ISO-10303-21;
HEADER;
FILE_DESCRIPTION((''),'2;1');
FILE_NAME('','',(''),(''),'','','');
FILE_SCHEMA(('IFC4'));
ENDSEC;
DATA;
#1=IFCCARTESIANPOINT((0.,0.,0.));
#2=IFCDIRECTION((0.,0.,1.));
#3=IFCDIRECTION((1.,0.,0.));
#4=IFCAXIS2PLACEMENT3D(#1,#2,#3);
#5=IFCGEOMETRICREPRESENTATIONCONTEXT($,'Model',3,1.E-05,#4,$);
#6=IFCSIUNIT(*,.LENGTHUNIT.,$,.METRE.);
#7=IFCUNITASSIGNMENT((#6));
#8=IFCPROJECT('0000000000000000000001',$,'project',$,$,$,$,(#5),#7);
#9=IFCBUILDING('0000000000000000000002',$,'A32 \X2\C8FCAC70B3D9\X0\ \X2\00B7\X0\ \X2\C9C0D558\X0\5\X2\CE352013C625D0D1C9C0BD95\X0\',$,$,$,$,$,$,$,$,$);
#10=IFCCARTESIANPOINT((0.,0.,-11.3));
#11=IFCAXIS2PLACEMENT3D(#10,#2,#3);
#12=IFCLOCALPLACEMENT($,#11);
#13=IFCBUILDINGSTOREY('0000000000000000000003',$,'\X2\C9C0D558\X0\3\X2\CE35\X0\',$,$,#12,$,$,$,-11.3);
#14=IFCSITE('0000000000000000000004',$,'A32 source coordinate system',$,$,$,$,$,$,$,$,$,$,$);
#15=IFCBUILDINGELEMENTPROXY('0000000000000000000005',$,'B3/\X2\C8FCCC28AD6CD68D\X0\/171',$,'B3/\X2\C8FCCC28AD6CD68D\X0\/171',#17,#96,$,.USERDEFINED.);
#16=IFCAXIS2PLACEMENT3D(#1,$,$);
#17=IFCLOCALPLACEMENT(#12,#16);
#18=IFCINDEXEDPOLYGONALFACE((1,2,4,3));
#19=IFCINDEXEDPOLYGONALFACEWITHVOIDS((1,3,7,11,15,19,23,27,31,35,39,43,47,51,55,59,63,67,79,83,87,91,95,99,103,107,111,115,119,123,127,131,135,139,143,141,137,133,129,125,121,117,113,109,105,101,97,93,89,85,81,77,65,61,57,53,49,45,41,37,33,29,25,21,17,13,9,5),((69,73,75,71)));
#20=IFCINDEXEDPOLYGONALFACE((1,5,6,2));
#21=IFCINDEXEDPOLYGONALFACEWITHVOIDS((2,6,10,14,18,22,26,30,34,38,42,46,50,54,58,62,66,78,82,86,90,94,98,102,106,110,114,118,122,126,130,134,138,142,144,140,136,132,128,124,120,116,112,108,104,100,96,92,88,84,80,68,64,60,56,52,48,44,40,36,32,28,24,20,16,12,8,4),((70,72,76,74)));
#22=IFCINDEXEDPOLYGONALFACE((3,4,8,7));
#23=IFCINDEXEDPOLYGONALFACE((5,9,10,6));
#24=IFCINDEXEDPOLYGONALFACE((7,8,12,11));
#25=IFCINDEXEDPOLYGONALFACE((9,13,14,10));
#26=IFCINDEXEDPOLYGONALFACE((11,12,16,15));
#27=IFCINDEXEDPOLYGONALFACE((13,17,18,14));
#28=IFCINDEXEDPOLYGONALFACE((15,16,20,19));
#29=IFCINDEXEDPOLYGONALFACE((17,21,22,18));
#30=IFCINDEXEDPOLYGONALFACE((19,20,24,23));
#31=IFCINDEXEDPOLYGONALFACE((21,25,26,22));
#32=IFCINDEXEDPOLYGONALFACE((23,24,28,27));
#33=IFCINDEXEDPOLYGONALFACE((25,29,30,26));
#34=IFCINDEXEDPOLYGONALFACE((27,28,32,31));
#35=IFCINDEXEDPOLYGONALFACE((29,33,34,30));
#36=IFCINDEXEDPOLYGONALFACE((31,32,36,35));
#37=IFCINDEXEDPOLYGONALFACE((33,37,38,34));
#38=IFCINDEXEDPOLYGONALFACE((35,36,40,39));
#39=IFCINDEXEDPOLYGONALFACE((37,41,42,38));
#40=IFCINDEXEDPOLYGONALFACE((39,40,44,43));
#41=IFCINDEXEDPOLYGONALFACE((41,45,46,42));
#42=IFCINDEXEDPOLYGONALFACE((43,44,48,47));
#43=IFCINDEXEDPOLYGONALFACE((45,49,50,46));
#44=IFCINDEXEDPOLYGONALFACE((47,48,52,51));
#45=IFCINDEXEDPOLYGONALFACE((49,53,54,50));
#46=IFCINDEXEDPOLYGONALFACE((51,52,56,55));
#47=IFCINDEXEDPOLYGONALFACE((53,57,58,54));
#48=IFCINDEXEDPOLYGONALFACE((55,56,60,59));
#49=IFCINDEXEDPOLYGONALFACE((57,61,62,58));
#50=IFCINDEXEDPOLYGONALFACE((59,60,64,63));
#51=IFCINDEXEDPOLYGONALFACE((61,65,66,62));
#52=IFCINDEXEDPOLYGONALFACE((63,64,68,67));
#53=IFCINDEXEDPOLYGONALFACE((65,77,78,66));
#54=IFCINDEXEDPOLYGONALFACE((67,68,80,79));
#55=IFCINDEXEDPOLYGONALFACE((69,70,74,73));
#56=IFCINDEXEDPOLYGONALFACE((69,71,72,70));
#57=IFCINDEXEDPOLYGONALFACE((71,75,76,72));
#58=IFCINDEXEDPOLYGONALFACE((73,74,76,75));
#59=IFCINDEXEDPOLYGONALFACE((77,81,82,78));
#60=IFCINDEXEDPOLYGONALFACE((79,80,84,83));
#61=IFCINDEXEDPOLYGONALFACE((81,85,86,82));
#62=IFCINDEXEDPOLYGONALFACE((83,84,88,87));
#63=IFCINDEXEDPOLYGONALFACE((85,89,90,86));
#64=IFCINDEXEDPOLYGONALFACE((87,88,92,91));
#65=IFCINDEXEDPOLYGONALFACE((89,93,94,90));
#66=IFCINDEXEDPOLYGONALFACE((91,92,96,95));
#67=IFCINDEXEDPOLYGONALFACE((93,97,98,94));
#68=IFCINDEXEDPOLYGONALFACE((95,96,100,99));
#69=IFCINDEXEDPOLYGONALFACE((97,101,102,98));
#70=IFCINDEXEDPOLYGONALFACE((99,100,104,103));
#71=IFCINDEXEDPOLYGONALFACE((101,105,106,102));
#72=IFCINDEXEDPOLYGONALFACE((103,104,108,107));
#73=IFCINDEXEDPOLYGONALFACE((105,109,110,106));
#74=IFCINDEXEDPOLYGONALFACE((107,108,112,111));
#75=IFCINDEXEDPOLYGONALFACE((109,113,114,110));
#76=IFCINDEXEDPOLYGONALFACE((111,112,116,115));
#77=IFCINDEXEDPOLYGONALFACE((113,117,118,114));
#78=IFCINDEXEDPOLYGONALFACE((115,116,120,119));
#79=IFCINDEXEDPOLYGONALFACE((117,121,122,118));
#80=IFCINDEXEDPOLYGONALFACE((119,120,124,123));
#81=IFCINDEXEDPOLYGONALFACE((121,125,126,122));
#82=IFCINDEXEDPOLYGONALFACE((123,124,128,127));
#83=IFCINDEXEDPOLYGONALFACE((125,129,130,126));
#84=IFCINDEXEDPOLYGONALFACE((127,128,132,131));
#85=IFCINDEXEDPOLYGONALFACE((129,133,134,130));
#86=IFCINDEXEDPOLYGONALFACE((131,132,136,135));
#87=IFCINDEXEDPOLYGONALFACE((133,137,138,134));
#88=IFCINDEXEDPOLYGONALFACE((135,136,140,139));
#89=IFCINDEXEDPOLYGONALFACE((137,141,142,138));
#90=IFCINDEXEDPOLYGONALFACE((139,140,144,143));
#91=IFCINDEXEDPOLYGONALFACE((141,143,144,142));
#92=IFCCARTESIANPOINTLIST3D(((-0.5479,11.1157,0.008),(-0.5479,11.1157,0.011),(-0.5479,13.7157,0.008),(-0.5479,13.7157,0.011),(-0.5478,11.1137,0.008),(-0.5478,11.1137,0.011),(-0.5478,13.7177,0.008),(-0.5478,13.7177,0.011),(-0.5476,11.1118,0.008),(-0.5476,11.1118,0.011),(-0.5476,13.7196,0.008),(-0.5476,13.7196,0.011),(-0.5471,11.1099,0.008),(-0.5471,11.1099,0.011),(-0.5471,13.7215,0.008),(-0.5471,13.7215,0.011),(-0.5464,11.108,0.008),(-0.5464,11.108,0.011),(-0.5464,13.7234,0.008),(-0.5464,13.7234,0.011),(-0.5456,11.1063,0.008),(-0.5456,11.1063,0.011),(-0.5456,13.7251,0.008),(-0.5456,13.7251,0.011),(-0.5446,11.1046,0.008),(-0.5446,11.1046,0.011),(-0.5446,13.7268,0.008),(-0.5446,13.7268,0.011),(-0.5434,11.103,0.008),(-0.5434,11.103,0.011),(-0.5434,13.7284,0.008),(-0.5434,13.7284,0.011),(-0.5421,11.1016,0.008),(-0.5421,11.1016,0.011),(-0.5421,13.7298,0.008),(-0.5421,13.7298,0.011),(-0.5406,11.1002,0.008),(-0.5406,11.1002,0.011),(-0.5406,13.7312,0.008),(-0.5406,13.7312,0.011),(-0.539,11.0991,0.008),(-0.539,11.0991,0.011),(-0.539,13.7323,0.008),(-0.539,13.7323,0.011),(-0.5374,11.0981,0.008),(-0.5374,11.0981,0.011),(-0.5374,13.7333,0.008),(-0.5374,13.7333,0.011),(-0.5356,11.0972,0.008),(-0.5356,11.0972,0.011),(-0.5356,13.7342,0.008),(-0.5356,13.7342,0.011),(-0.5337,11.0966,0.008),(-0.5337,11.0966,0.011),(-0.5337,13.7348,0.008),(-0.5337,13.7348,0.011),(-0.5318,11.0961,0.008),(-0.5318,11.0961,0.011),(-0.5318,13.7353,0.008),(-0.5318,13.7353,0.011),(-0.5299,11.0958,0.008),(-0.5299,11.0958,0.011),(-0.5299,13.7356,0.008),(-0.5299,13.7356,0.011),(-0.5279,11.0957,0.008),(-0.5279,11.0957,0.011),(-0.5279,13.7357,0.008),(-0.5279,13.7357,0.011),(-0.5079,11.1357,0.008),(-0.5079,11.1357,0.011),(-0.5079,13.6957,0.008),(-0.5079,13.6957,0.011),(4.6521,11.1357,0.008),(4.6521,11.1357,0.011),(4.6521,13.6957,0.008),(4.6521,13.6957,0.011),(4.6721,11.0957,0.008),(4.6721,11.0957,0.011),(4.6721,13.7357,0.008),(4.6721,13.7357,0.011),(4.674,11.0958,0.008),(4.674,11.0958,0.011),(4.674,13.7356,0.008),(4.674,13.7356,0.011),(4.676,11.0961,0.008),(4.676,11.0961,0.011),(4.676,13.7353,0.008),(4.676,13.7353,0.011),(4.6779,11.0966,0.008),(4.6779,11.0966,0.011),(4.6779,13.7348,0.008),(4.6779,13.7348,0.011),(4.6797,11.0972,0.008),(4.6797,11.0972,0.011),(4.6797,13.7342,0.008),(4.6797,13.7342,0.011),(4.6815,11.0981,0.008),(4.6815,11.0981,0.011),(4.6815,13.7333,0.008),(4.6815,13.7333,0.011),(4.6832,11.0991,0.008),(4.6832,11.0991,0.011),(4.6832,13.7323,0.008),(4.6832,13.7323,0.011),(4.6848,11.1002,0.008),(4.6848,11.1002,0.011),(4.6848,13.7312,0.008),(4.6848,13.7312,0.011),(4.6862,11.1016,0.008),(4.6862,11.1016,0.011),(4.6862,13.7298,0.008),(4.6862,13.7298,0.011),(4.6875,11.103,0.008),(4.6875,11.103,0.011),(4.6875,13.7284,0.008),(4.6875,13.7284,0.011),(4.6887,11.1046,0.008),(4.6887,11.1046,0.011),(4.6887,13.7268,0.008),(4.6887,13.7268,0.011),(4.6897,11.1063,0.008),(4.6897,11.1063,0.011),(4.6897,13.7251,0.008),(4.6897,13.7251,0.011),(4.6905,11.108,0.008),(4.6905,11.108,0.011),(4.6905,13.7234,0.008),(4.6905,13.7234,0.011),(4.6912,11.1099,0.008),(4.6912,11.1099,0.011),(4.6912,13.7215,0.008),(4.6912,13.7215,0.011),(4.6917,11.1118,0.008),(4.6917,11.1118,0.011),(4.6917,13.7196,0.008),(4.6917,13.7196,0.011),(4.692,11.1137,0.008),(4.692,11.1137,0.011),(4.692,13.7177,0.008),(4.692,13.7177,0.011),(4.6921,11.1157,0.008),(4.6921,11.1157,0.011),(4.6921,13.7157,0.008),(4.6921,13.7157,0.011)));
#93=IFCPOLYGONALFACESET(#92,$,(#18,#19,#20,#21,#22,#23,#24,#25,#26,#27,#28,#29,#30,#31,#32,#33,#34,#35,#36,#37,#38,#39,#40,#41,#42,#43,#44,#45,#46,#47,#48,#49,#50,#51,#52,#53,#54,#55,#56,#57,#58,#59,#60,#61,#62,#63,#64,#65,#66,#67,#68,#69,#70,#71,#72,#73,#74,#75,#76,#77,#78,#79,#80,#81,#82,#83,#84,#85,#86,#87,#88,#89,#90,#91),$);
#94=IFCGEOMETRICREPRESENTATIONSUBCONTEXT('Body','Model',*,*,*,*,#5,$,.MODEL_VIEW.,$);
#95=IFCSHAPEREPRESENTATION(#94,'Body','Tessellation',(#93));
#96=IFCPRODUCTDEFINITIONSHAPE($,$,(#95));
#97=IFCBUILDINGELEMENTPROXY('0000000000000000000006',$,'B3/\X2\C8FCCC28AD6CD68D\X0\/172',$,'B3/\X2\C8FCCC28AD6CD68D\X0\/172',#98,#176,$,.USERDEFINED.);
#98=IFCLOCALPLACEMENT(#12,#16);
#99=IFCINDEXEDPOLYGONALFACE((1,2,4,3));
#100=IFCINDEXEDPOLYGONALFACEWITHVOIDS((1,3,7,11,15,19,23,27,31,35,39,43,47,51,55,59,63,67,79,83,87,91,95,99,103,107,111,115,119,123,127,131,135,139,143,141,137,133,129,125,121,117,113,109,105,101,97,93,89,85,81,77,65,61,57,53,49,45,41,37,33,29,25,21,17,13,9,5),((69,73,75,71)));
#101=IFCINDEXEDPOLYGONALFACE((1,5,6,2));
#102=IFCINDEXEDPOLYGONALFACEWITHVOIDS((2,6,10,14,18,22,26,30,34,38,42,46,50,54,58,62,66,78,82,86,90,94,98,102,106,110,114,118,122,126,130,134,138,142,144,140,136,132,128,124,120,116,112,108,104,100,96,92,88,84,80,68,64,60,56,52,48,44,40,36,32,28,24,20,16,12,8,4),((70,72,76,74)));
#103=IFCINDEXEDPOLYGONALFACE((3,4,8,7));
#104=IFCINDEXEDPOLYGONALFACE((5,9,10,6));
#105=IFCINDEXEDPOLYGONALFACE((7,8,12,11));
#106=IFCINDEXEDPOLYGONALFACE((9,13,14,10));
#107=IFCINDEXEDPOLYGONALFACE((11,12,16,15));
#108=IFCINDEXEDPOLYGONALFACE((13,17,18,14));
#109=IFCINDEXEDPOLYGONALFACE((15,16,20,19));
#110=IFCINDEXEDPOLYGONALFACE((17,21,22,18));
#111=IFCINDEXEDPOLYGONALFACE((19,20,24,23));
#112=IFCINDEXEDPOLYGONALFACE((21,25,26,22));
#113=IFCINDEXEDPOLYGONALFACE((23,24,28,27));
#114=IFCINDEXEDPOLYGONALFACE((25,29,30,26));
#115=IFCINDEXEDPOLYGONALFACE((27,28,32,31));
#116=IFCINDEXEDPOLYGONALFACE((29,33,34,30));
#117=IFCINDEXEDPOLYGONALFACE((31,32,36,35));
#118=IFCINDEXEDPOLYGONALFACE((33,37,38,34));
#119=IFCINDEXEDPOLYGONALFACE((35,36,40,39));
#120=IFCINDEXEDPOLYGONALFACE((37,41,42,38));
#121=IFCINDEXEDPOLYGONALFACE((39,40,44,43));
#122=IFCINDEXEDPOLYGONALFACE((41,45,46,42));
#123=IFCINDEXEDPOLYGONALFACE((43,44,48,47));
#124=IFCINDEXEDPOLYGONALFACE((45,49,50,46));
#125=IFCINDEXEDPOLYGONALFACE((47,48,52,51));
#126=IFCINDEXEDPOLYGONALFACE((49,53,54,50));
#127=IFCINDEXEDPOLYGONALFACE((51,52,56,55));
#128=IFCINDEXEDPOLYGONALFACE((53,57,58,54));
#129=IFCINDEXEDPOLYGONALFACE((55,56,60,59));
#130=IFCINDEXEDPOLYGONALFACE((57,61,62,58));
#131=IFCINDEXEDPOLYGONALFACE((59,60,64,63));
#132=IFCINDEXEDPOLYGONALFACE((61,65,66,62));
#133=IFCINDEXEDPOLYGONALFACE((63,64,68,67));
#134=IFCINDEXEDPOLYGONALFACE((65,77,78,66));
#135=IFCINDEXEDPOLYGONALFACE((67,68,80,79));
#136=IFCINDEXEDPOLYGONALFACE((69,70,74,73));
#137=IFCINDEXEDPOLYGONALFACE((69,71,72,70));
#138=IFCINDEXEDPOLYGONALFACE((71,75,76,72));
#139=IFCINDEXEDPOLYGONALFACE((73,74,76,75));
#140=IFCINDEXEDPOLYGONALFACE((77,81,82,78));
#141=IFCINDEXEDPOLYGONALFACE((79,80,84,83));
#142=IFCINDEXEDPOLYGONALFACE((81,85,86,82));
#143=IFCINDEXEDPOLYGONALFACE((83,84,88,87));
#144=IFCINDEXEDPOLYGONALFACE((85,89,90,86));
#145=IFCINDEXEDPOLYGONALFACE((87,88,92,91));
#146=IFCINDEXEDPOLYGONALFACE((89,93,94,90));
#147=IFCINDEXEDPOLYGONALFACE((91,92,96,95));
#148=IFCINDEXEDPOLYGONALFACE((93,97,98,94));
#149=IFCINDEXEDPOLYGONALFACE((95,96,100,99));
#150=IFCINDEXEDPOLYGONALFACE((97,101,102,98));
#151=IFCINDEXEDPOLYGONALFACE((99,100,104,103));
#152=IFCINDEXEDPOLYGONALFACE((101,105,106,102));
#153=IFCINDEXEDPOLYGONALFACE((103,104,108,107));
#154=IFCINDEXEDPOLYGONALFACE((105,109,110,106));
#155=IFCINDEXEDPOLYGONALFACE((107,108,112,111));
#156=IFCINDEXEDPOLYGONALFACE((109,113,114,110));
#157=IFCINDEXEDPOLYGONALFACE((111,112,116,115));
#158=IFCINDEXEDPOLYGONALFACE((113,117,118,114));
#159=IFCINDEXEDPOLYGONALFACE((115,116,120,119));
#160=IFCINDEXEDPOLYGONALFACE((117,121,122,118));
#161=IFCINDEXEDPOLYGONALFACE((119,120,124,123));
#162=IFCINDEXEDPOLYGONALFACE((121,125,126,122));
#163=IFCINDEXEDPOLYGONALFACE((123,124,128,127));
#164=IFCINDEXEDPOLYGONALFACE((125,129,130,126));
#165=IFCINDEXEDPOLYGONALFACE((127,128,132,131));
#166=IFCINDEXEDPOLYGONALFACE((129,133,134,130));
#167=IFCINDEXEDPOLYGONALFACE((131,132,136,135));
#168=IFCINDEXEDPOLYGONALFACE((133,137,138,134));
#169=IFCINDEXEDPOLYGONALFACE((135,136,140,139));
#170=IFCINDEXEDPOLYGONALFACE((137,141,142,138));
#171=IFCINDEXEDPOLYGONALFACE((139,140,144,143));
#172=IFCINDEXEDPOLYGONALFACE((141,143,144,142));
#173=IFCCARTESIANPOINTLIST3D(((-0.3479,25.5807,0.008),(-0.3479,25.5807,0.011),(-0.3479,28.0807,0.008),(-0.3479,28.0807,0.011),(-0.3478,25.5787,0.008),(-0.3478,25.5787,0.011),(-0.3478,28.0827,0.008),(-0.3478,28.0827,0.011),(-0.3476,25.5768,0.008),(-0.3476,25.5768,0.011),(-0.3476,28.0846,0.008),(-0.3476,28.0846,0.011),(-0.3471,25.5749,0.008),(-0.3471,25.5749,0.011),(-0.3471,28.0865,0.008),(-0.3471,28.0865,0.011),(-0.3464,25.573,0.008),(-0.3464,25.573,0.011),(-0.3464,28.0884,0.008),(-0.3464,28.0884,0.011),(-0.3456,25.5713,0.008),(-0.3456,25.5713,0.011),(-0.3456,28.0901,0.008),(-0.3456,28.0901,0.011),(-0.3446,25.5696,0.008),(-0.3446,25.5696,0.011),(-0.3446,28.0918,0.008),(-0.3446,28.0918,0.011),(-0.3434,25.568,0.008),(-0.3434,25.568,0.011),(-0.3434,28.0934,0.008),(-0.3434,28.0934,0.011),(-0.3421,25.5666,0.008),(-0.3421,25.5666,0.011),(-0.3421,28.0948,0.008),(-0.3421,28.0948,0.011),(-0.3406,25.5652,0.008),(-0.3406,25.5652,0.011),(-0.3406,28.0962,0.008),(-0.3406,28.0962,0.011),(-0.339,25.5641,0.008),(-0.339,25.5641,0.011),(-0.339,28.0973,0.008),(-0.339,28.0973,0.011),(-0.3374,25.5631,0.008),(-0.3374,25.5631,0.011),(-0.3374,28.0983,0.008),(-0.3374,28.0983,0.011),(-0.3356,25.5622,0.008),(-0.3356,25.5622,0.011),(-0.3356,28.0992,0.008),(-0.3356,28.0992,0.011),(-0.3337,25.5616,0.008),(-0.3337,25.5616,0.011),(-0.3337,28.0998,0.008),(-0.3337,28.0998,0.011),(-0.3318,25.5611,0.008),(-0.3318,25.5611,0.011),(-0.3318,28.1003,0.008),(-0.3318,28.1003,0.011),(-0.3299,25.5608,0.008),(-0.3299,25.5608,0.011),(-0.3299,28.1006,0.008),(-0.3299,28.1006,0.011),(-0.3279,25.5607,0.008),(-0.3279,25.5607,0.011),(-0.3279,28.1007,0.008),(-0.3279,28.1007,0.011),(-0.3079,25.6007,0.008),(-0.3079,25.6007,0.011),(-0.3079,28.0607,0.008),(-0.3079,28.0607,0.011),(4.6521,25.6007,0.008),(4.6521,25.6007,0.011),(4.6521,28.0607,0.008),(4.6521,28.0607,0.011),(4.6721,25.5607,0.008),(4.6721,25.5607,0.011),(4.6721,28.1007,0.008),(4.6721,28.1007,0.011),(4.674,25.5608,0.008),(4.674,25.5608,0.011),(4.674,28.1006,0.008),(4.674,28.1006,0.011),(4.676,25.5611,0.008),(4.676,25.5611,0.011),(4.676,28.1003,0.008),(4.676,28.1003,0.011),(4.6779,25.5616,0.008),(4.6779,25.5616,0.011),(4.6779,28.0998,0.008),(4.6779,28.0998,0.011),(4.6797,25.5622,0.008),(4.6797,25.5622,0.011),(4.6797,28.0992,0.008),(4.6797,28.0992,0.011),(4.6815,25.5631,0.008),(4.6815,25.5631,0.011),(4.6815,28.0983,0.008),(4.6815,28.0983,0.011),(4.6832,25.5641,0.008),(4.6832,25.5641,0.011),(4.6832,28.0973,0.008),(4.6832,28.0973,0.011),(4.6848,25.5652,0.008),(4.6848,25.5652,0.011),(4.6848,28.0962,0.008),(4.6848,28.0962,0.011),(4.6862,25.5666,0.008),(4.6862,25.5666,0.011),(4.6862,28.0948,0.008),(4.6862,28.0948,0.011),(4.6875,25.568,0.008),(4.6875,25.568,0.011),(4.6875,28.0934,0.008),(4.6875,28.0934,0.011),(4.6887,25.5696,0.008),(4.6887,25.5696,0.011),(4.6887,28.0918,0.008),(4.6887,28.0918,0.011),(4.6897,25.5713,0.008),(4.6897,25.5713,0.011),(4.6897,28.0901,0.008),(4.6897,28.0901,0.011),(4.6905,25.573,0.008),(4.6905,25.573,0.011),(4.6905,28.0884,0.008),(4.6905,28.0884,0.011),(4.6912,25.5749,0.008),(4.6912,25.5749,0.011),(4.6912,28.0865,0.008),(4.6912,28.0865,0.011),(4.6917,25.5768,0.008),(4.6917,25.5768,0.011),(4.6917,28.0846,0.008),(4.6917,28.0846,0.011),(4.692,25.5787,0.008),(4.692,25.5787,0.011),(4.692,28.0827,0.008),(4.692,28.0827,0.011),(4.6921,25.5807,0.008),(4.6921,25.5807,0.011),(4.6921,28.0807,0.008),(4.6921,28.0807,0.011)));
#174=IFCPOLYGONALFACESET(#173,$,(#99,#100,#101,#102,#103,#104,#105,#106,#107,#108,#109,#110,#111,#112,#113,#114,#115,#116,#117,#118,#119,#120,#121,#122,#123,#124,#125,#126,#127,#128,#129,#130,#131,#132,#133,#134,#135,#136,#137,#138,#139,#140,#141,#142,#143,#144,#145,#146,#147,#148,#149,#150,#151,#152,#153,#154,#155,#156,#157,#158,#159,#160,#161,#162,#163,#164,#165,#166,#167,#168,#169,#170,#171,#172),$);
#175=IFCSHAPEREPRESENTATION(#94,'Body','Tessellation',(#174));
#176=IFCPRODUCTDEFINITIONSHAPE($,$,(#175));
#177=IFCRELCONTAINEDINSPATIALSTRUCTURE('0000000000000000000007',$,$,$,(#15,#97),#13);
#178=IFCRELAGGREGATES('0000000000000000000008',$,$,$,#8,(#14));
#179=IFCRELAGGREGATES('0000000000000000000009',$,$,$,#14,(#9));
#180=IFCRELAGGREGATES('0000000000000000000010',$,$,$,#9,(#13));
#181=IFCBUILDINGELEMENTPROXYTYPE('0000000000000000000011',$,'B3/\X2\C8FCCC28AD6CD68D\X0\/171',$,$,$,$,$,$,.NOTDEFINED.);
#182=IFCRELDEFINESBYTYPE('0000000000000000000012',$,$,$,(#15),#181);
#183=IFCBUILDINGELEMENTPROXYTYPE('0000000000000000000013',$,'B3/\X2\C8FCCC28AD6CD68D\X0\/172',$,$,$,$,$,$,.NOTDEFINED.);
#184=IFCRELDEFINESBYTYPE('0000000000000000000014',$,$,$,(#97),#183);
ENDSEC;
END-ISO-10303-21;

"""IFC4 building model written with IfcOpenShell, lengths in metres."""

from ifc_helpers import new_model, si_unit, frame, origin, origin_with_axes, place, context, subcontext, project, spatial, polyline, outline, extrude, source, transform, mapped, type_object, type_shapes, element, save


model = new_model("IFC4")

# Units and contexts
model_context = context("Model", 3, precision=1e-05, world=origin_with_axes())
body_context = subcontext(model_context, "Body", "Model", "MODEL_VIEW")
ifc_project = project(units=[si_unit("LENGTHUNIT", "METRE")], contexts=[model_context])

# Site, building, storey
site = spatial("IfcSite", under=ifc_project, Name="A32 source coordinate system")
building = spatial("IfcBuilding", under=site, Name="A32 주거동 · 지하5층–옥탑지붕")
storey_placement = place(None, frame((0.0, 0.0, -11.3), z_axis=(0.0, 0.0, 1.0), x_axis=(1.0, 0.0, 0.0)))
storey = spatial("IfcBuildingStorey", under=building, at=storey_placement, Name="지하3층", Elevation=-11.3)

# Building element proxies
building_element_proxy_type_1 = type_object("IfcBuildingElementProxyType", Name="B3/주차구획/171", PredefinedType="NOTDEFINED")
shared_shape_1 = source(origin(), body_context, "Body", "SweptSolid", [
    extrude(outline(polyline([(-0.5279, 11.0957), (-0.5299, 11.0958), (-0.5318, 11.0961), (-0.5337, 11.0966), (-0.5356, 11.0972), (-0.5374, 11.0981), (-0.539, 11.0991), (-0.5406, 11.1002), (-0.5421, 11.1016), (-0.5434, 11.103), (-0.5446, 11.1046), (-0.5456, 11.1063), (-0.5464, 11.108), (-0.5471, 11.1099), (-0.5476, 11.1118), (-0.5478, 11.1137), (-0.5479, 11.1157), (-0.5479, 13.7157), (-0.5478, 13.7177), (-0.5476, 13.7196), (-0.5471, 13.7215), (-0.5464, 13.7234), (-0.5456, 13.7251), (-0.5446, 13.7268), (-0.5434, 13.7284), (-0.5421, 13.7298), (-0.5406, 13.7312), (-0.539, 13.7323), (-0.5374, 13.7333), (-0.5356, 13.7342), (-0.5337, 13.7348), (-0.5318, 13.7353), (-0.5299, 13.7356), (-0.5279, 13.7357), (4.6721, 13.7357), (4.674, 13.7356), (4.676, 13.7353), (4.6779, 13.7348), (4.6797, 13.7342), (4.6815, 13.7333), (4.6832, 13.7323), (4.6848, 13.7312), (4.6862, 13.7298), (4.6875, 13.7284), (4.6887, 13.7268), (4.6897, 13.7251), (4.6905, 13.7234), (4.6912, 13.7215), (4.6917, 13.7196), (4.692, 13.7177), (4.6921, 13.7157), (4.6921, 11.1157), (4.692, 11.1137), (4.6917, 11.1118), (4.6912, 11.1099), (4.6905, 11.108), (4.6897, 11.1063), (4.6887, 11.1046), (4.6875, 11.103), (4.6862, 11.1016), (4.6848, 11.1002), (4.6832, 11.0991), (4.6815, 11.0981), (4.6797, 11.0972), (4.6779, 11.0966), (4.676, 11.0961), (4.674, 11.0958), (4.6721, 11.0957), (-0.5279, 11.0957)]), holes=[polyline([(-0.5079, 11.1357), (4.6521, 11.1357), (4.6521, 13.6957), (-0.5079, 13.6957), (-0.5079, 11.1357)])]), frame((0.0, 0.0, 0.008)), (0.0, 0.0, 1.0), 0.003),
])
type_shapes(building_element_proxy_type_1, [shared_shape_1])
proxy_1_placement = place(storey_placement, origin_with_axes())
element("IfcBuildingElementProxy", 1, at=proxy_1_placement, inside=storey, type_object=building_element_proxy_type_1, Name="B3/주차구획/171", ObjectType="B3/주차구획/171", PredefinedType="USERDEFINED", context=body_context, shape_type="MappedRepresentation", body=[
    mapped(shared_shape_1, transform((0.0, 0.0, 0.0), scale=1.0)),
])
building_element_proxy_type_2 = type_object("IfcBuildingElementProxyType", Name="B3/주차구획/172", PredefinedType="NOTDEFINED")
shared_shape_2 = source(origin(), body_context, "Body", "SweptSolid", [
    extrude(outline(polyline([(-0.3279, 25.5607), (-0.3299, 25.5608), (-0.3318, 25.5611), (-0.3337, 25.5616), (-0.3356, 25.5622), (-0.3374, 25.5631), (-0.339, 25.5641), (-0.3406, 25.5652), (-0.3421, 25.5666), (-0.3434, 25.568), (-0.3446, 25.5696), (-0.3456, 25.5713), (-0.3464, 25.573), (-0.3471, 25.5749), (-0.3476, 25.5768), (-0.3478, 25.5787), (-0.3479, 25.5807), (-0.3479, 28.0807), (-0.3478, 28.0827), (-0.3476, 28.0846), (-0.3471, 28.0865), (-0.3464, 28.0884), (-0.3456, 28.0901), (-0.3446, 28.0918), (-0.3434, 28.0934), (-0.3421, 28.0948), (-0.3406, 28.0962), (-0.339, 28.0973), (-0.3374, 28.0983), (-0.3356, 28.0992), (-0.3337, 28.0998), (-0.3318, 28.1003), (-0.3299, 28.1006), (-0.3279, 28.1007), (4.6721, 28.1007), (4.674, 28.1006), (4.676, 28.1003), (4.6779, 28.0998), (4.6797, 28.0992), (4.6815, 28.0983), (4.6832, 28.0973), (4.6848, 28.0962), (4.6862, 28.0948), (4.6875, 28.0934), (4.6887, 28.0918), (4.6897, 28.0901), (4.6905, 28.0884), (4.6912, 28.0865), (4.6917, 28.0846), (4.692, 28.0827), (4.6921, 28.0807), (4.6921, 25.5807), (4.692, 25.5787), (4.6917, 25.5768), (4.6912, 25.5749), (4.6905, 25.573), (4.6897, 25.5713), (4.6887, 25.5696), (4.6875, 25.568), (4.6862, 25.5666), (4.6848, 25.5652), (4.6832, 25.5641), (4.6815, 25.5631), (4.6797, 25.5622), (4.6779, 25.5616), (4.676, 25.5611), (4.674, 25.5608), (4.6721, 25.5607), (-0.3279, 25.5607)]), holes=[polyline([(-0.3079, 25.6007), (4.6521, 25.6007), (4.6521, 28.0607), (-0.3079, 28.0607), (-0.3079, 25.6007)])]), frame((0.0, 0.0, 0.008)), (0.0, 0.0, 1.0), 0.003),
])
type_shapes(building_element_proxy_type_2, [shared_shape_2])
proxy_2_placement = place(storey_placement, origin_with_axes())
element("IfcBuildingElementProxy", 2, at=proxy_2_placement, inside=storey, type_object=building_element_proxy_type_2, Name="B3/주차구획/172", ObjectType="B3/주차구획/172", PredefinedType="USERDEFINED", context=body_context, shape_type="MappedRepresentation", body=[
    mapped(shared_shape_2, transform((0.0, 0.0, 0.0), scale=1.0)),
])

save(model, "model.ifc")
